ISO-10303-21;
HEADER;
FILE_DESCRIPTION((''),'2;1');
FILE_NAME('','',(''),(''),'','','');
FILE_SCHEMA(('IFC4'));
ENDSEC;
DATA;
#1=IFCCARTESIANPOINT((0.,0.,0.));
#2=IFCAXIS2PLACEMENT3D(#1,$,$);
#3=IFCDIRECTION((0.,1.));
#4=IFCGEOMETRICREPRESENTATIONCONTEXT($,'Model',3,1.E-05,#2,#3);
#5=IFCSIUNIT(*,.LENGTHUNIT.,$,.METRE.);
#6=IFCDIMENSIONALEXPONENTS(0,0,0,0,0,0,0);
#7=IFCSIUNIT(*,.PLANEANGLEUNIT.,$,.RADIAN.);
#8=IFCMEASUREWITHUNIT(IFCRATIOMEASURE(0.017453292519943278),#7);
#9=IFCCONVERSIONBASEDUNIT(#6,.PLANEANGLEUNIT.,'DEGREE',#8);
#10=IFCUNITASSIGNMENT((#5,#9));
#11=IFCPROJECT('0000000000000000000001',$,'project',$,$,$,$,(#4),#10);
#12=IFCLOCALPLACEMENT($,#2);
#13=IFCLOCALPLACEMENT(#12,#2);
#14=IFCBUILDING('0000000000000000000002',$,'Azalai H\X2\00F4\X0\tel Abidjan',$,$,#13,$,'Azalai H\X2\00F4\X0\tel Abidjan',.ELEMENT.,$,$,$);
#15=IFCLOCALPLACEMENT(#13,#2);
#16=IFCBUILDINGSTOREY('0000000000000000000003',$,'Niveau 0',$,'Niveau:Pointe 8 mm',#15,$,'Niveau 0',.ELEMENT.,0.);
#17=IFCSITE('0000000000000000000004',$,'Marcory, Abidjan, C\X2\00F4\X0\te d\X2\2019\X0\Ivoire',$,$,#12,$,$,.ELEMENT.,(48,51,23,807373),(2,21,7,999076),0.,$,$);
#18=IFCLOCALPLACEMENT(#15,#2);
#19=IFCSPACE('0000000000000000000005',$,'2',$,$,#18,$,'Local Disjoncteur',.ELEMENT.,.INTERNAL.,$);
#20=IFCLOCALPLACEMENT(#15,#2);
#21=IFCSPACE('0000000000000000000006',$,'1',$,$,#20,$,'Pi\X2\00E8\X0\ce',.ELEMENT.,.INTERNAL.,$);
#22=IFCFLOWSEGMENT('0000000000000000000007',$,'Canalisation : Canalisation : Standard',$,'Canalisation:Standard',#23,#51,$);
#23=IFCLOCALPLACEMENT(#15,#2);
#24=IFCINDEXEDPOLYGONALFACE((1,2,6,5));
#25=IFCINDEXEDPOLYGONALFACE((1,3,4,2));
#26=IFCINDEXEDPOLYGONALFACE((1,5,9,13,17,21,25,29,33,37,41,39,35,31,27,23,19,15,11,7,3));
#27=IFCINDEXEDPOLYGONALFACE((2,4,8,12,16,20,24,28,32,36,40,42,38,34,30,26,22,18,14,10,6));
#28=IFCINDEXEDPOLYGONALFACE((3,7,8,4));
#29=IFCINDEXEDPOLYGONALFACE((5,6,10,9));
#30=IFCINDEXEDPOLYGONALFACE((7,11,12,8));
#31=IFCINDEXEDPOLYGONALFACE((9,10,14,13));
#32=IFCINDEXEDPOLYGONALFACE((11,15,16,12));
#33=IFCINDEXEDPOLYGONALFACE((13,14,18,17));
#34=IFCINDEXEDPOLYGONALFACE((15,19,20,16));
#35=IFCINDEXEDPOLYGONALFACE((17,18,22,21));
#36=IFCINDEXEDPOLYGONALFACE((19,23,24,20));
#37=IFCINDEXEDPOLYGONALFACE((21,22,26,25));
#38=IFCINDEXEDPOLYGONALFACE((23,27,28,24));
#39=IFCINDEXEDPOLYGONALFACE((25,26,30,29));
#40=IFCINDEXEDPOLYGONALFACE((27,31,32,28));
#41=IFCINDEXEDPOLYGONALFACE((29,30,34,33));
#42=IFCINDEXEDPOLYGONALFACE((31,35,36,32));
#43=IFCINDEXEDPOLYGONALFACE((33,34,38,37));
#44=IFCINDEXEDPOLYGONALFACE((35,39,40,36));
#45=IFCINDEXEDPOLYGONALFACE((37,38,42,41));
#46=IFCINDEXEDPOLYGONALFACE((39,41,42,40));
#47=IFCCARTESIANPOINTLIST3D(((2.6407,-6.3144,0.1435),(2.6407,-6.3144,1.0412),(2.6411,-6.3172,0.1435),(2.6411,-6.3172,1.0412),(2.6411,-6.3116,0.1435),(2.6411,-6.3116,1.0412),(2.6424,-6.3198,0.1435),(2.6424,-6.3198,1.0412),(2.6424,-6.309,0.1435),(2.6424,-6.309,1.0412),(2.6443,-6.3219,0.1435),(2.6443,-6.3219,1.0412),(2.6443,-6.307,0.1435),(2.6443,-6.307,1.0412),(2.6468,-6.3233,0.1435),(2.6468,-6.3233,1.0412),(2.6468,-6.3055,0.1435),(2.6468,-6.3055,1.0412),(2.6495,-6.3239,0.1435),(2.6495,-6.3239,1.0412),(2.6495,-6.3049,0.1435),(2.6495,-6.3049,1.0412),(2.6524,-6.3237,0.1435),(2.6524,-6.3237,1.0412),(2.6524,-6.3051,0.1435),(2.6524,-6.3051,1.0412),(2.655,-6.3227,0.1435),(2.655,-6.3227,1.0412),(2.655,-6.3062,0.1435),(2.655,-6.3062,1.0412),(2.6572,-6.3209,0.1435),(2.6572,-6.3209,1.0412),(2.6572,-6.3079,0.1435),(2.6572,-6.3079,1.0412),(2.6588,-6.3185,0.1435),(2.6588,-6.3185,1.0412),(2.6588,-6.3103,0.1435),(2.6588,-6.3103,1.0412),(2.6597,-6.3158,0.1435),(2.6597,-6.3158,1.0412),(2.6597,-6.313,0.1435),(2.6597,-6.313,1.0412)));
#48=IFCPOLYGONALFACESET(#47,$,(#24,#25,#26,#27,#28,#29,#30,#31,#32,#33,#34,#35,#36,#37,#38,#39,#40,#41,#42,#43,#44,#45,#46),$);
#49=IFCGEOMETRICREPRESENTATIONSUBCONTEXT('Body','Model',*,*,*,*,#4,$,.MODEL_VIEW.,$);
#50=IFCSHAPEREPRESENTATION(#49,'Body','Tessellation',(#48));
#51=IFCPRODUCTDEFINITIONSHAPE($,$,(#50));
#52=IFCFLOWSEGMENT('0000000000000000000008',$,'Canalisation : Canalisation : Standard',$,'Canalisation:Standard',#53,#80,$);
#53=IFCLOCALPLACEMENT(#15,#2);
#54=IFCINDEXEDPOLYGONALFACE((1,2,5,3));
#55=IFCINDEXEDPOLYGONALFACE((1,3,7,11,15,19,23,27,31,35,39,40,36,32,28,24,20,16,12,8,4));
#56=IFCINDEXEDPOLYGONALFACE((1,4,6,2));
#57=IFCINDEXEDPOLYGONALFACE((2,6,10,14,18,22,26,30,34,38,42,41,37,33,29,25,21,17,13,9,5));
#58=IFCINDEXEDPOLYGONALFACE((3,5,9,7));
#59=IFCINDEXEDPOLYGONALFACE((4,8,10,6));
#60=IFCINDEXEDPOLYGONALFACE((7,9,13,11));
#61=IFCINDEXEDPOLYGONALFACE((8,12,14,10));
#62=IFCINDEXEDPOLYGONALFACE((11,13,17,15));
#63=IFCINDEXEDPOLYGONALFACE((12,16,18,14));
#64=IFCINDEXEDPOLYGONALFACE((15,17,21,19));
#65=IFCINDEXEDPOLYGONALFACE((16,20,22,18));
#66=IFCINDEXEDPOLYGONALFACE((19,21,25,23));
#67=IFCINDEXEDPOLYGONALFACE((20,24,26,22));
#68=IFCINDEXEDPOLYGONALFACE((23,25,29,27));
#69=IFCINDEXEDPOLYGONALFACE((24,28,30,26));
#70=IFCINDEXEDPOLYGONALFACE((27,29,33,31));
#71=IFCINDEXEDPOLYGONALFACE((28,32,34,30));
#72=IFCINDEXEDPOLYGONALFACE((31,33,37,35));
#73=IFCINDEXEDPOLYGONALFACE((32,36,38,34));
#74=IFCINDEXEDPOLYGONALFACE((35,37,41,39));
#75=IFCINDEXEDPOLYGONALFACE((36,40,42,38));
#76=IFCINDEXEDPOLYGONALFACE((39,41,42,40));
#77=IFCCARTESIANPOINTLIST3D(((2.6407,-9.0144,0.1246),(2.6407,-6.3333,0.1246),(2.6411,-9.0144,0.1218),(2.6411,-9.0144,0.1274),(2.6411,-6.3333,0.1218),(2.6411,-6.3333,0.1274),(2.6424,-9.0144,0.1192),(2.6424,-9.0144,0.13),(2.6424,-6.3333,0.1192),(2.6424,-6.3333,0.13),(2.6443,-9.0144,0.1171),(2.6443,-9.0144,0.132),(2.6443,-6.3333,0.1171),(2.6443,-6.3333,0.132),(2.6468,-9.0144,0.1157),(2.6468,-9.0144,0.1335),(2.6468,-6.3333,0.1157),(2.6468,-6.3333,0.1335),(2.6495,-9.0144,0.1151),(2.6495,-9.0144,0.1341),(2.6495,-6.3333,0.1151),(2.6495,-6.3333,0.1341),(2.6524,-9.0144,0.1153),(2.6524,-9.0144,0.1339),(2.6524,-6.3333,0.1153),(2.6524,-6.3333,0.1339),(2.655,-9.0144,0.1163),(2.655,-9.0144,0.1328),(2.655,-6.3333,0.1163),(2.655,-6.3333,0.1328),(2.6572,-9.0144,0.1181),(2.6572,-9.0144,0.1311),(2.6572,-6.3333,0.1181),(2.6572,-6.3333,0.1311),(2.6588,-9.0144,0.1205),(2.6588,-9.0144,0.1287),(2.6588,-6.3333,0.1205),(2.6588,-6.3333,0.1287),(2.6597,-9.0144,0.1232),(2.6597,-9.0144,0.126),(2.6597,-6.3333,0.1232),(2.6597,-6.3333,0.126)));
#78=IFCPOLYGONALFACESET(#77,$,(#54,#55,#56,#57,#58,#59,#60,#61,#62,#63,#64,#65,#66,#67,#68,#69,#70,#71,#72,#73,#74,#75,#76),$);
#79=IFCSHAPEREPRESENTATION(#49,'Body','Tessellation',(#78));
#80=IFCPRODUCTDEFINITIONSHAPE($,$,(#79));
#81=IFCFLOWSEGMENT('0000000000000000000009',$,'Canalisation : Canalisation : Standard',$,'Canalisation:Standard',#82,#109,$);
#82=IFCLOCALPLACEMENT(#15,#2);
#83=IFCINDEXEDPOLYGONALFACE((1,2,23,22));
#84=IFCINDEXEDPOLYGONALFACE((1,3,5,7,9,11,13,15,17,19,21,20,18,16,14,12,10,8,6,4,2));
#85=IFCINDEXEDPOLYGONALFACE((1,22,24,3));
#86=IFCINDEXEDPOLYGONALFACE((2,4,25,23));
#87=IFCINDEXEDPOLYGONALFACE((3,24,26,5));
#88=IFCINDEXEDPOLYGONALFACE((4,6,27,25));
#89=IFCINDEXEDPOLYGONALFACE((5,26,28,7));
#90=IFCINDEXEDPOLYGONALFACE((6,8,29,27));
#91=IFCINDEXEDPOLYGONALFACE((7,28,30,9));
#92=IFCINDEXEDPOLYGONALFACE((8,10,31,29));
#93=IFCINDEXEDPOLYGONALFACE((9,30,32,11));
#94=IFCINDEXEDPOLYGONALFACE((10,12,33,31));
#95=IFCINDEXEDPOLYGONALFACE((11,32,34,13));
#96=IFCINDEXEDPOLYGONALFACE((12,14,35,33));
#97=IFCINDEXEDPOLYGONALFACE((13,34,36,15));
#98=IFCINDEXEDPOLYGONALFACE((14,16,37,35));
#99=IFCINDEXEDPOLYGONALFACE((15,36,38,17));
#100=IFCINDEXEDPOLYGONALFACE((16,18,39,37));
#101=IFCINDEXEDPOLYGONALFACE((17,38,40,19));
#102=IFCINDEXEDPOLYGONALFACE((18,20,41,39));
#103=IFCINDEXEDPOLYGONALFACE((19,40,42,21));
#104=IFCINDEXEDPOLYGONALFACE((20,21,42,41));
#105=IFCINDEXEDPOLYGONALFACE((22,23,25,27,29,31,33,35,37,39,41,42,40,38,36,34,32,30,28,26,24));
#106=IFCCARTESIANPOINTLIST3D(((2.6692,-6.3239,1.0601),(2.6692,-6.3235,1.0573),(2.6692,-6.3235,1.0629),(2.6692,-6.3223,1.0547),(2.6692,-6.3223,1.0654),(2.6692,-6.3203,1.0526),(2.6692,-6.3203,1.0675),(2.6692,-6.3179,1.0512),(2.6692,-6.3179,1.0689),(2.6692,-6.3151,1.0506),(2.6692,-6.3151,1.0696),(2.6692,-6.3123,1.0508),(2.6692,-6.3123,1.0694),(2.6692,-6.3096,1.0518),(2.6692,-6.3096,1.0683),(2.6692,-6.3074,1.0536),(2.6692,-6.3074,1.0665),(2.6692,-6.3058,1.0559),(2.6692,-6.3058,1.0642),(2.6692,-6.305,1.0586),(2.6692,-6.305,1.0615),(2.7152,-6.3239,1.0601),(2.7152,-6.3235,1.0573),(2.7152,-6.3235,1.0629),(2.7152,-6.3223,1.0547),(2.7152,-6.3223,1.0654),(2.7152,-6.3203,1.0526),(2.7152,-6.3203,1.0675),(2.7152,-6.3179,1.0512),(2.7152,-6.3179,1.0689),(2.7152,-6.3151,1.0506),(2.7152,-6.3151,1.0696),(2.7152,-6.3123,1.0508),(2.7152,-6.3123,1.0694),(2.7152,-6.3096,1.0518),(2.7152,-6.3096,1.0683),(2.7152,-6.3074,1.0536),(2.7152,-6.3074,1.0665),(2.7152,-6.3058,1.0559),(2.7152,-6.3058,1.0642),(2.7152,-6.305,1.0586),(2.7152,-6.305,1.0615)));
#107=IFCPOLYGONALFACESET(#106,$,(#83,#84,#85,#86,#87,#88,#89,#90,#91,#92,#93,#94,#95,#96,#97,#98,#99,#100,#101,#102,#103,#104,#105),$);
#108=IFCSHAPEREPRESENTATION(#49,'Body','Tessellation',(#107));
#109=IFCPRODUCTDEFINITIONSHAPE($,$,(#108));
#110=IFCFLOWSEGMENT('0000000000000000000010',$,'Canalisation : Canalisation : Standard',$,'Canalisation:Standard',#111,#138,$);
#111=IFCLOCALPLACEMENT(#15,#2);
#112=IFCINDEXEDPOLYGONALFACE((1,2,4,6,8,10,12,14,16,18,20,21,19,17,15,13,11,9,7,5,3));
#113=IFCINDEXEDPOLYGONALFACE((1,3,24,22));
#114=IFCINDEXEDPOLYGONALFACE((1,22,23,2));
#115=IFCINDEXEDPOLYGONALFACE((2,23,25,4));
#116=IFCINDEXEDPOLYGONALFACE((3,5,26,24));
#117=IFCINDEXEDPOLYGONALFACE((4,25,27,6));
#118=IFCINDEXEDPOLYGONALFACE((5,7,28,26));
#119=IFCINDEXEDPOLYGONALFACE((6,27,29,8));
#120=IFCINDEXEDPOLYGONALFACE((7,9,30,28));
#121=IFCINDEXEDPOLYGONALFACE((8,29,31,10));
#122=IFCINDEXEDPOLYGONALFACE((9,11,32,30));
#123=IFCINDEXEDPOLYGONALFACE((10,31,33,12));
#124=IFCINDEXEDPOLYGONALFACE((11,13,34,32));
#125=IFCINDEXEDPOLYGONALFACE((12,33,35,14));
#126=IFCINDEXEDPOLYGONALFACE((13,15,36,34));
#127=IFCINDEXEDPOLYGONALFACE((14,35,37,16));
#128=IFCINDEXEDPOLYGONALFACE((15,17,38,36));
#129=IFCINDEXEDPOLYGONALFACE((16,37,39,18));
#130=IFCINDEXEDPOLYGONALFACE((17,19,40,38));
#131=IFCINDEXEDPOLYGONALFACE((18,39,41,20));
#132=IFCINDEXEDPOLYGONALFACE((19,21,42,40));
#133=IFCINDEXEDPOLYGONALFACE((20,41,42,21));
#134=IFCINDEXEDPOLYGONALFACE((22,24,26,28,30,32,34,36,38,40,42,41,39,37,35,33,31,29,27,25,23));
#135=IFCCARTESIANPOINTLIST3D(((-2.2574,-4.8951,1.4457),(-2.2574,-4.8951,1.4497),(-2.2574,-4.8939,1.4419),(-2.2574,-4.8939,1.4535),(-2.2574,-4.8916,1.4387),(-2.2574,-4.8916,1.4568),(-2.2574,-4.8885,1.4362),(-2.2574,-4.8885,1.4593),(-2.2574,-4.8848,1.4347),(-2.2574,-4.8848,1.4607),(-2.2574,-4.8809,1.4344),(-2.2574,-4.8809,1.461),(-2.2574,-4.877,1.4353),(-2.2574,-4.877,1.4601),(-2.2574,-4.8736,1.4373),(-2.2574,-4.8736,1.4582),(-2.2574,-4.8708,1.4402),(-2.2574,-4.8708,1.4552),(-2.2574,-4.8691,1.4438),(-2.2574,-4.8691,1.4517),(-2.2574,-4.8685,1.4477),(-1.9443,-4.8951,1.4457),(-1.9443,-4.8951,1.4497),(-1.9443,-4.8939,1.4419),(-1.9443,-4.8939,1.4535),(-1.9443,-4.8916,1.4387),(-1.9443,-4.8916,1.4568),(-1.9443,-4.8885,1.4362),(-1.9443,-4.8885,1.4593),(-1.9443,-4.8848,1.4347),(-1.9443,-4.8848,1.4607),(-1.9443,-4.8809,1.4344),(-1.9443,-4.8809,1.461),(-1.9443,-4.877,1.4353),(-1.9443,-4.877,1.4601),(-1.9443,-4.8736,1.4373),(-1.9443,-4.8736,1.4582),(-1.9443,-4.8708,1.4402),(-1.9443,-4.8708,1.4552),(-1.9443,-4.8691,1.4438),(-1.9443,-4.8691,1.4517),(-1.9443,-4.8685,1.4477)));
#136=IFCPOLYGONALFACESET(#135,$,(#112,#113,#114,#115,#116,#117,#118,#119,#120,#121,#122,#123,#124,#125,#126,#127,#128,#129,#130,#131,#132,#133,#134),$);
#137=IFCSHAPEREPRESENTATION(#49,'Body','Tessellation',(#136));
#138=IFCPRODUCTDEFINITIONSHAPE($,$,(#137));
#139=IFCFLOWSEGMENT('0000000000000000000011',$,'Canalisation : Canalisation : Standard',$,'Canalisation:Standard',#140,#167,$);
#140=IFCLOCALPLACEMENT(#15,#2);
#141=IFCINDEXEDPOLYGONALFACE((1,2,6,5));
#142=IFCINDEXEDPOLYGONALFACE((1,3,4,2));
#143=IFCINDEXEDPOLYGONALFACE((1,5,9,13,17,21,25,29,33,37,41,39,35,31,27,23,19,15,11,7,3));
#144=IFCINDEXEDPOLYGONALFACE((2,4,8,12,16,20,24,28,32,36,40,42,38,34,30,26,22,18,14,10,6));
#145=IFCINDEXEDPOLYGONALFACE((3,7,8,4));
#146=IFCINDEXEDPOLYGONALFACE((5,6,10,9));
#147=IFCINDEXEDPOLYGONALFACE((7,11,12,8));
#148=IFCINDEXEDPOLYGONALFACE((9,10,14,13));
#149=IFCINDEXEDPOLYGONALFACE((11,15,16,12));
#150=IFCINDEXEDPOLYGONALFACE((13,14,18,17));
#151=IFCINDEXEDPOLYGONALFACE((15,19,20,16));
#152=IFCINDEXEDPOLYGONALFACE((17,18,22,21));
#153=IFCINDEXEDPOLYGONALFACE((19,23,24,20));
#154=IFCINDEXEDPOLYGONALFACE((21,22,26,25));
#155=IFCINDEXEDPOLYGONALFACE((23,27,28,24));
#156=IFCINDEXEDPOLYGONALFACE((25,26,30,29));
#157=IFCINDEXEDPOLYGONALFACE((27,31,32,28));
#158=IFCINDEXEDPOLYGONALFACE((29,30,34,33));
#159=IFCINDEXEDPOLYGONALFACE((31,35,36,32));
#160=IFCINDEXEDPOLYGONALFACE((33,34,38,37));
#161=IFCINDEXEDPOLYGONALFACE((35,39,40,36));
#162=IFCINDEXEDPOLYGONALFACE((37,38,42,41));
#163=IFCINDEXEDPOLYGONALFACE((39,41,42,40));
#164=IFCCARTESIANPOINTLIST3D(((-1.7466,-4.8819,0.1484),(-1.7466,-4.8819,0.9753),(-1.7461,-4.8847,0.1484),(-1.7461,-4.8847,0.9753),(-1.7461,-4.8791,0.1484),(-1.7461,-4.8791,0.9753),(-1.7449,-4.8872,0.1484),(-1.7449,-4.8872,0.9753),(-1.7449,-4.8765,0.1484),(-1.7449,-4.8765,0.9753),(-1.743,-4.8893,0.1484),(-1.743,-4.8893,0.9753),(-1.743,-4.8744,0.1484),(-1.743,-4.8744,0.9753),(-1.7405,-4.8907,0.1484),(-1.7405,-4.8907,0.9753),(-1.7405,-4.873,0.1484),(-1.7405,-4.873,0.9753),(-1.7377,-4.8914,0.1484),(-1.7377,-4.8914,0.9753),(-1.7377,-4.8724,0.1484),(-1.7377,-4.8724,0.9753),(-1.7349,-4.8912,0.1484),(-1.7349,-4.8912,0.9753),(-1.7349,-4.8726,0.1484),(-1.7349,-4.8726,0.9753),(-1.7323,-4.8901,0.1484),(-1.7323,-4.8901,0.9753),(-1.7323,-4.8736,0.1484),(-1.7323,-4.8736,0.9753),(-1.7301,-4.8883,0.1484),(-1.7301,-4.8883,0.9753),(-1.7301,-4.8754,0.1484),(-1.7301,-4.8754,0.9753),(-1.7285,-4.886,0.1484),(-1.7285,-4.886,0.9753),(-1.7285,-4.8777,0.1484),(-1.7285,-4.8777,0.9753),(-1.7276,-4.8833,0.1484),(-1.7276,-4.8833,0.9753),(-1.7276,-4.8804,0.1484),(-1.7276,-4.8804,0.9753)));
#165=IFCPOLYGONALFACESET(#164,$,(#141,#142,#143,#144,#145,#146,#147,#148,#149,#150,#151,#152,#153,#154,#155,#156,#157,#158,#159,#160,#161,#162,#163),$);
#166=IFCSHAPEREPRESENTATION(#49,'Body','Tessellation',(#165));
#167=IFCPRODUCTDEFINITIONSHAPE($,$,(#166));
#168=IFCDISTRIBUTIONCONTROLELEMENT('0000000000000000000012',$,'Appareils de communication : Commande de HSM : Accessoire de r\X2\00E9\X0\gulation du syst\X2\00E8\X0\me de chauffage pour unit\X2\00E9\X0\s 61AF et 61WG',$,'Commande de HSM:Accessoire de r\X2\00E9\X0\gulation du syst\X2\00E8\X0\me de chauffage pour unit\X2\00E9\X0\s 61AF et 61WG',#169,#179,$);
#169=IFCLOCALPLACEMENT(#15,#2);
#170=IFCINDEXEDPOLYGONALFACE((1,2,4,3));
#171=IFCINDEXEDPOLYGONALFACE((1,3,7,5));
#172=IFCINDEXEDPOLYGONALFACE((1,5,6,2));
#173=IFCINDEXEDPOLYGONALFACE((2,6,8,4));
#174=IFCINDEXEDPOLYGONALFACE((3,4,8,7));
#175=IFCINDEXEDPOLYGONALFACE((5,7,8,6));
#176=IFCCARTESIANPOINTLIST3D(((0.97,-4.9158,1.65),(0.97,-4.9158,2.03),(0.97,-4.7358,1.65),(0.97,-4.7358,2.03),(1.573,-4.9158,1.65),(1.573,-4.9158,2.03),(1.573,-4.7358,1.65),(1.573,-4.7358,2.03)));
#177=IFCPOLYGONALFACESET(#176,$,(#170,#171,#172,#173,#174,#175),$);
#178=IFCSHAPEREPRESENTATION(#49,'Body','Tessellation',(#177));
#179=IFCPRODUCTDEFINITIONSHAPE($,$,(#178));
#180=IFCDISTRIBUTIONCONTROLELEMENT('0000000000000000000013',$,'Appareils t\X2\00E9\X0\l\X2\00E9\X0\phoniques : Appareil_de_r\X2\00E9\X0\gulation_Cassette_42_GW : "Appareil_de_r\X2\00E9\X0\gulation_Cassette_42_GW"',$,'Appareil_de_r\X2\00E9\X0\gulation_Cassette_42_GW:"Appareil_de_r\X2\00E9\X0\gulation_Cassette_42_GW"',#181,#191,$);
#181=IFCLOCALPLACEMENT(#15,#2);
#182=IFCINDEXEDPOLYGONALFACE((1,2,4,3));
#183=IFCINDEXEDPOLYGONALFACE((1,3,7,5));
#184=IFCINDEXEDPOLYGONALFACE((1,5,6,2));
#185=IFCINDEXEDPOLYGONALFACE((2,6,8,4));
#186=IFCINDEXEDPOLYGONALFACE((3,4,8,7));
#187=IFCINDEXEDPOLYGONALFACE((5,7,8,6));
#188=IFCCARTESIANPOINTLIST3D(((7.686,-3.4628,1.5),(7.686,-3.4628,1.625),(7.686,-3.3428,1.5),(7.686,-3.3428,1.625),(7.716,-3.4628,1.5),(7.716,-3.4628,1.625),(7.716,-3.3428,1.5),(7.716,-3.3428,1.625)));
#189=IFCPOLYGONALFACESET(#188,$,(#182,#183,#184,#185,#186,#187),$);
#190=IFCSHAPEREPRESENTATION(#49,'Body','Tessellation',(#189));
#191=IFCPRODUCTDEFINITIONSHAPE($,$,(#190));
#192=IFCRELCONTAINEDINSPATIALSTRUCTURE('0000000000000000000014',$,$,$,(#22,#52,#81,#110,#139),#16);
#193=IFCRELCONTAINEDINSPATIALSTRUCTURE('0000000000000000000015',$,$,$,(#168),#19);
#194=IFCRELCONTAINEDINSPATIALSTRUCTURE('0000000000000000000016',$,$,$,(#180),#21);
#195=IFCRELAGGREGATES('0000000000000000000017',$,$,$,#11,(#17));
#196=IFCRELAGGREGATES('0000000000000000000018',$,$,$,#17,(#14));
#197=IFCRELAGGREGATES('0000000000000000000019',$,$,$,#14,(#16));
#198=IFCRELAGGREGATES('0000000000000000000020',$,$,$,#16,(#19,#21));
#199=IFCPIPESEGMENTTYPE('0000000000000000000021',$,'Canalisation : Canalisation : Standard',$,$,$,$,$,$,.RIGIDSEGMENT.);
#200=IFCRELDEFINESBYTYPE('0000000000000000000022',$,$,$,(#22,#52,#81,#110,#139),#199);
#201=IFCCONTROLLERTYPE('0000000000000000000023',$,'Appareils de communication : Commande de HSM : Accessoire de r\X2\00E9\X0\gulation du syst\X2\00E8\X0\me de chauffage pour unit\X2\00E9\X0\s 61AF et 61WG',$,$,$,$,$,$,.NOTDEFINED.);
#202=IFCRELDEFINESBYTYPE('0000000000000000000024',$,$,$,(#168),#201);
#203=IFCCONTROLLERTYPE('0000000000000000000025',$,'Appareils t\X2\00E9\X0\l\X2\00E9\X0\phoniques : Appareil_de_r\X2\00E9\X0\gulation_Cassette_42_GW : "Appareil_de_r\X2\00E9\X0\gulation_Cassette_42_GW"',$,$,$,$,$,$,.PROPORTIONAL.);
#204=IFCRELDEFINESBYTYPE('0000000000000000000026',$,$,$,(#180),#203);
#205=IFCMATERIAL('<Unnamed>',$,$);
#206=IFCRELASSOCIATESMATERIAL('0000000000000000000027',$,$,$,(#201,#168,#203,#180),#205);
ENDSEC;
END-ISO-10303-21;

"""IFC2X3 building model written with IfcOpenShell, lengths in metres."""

from ifc_helpers import new_model, entity, si_unit, converted_unit, direction, frame, frame_2d, origin, origin_2d_with_axis, place, context, subcontext, project, spatial, rectangle, circle, extrude, source, transform, mapped, material, type_object, type_shapes, element, save


model = new_model("IFC2X3")

# Units and contexts
model_context = context("Model", 3, precision=1e-05, world=origin(), true_north=direction((0.0, 1.0)))
body_context = subcontext(model_context, "Body", "Model", "MODEL_VIEW")
ifc_project = project(units=[si_unit("LENGTHUNIT", "METRE"), converted_unit("PLANEANGLEUNIT", "DEGREE", entity("IfcRatioMeasure", 0.017453292519943278), si_unit("PLANEANGLEUNIT", "RADIAN"), dimensions=[0, 0, 0, 0, 0, 0, 0])], contexts=[model_context])

# Site, building, storey
site_placement = place(None, origin())
site = spatial("IfcSite", under=ifc_project, at=site_placement, Name="Marcory, Abidjan, Côte d’Ivoire", CompositionType="ELEMENT", RefLatitude=(48, 51, 23, 807373), RefLongitude=(2, 21, 7, 999076), RefElevation=0.0)
building_placement = place(site_placement, origin())
building = spatial("IfcBuilding", under=site, at=building_placement, Name="Azalai Hôtel Abidjan", LongName="Azalai Hôtel Abidjan", CompositionType="ELEMENT")
storey_placement = place(building_placement, origin())
storey = spatial("IfcBuildingStorey", under=building, at=storey_placement, Name="Niveau 0", ObjectType="Niveau:Pointe 8 mm", LongName="Niveau 0", CompositionType="ELEMENT", Elevation=0.0)

# Flow segments
pipe_segment_type = type_object("IfcPipeSegmentType", Name="Canalisation : Canalisation : Standard", PredefinedType="RIGIDSEGMENT")
flow_segment_1_placement = place(storey_placement, origin())
element("IfcFlowSegment", 1, at=flow_segment_1_placement, inside=storey, type_object=pipe_segment_type, Name="Canalisation : Canalisation : Standard", ObjectType="Canalisation:Standard", context=body_context, shape_type="SweptSolid", body=[
    extrude(circle(Radius=0.0095, at=origin_2d_with_axis()), frame((2.6502, -6.3144, 0.1435), z_axis=(0.0, 0.0, 1.0), x_axis=(-1.0, 0.0, 0.0)), (0.0, 0.0, 1.0), 0.8977),
])
flow_segment_2_placement = place(storey_placement, origin())
element("IfcFlowSegment", 2, at=flow_segment_2_placement, inside=storey, type_object=pipe_segment_type, Name="Canalisation : Canalisation : Standard", ObjectType="Canalisation:Standard", context=body_context, shape_type="SweptSolid", body=[
    extrude(circle(Radius=0.0095, at=frame_2d((0.0, 0.0), x_axis=(1.0, 0.0))), frame((2.6502, -9.0144, 0.1246), z_axis=(0.0, 1.0, 0.0), x_axis=(-1.0, 0.0, 0.0)), (0.0, 0.0, 1.0), 2.6811),
])
flow_segment_3_placement = place(storey_placement, origin())
element("IfcFlowSegment", 3, at=flow_segment_3_placement, inside=storey, type_object=pipe_segment_type, Name="Canalisation : Canalisation : Standard", ObjectType="Canalisation:Standard", context=body_context, shape_type="SweptSolid", body=[
    extrude(circle(Radius=0.0095, at=origin_2d_with_axis()), frame((2.6692, -6.3144, 1.0601), z_axis=(1.0, 0.0, 0.0), x_axis=(0.0, -1.0, 0.0)), (0.0, 0.0, 1.0), 0.0461),
])
flow_segment_4_placement = place(storey_placement, origin())
element("IfcFlowSegment", 4, at=flow_segment_4_placement, inside=storey, type_object=pipe_segment_type, Name="Canalisation : Canalisation : Standard", ObjectType="Canalisation:Standard", context=body_context, shape_type="SweptSolid", body=[
    extrude(circle(Radius=0.0133, at=frame_2d((0.0, 0.0), x_axis=(1.0, 0.0))), frame((-2.2574, -4.8819, 1.4477), z_axis=(1.0, 0.0, 0.0), x_axis=(0.0, 1.0, 0.0)), (0.0, 0.0, 1.0), 0.3131),
])
flow_segment_5_placement = place(storey_placement, origin())
element("IfcFlowSegment", 5, at=flow_segment_5_placement, inside=storey, type_object=pipe_segment_type, Name="Canalisation : Canalisation : Standard", ObjectType="Canalisation:Standard", context=body_context, shape_type="SweptSolid", body=[
    extrude(circle(Radius=0.0095, at=origin_2d_with_axis()), frame((-1.737, -4.8819, 0.1484), z_axis=(0.0, 0.0, 1.0), x_axis=(-1.0, 0.0, 0.0)), (0.0, 0.0, 1.0), 0.8269),
])

# Shared definitions
space_1_placement = place(storey_placement, origin())
space_1 = spatial("IfcSpace", under=storey, at=space_1_placement, Name="2", LongName="Local Disjoncteur", CompositionType="ELEMENT", InteriorOrExteriorSpace="INTERNAL")

# Distribution control element
ifc_material_1 = material(Name="<Unnamed>")
controller_type_1 = type_object("IfcControllerType", Name="Appareils de communication : Commande de HSM : Accessoire de régulation du système de chauffage pour unités 61AF et 61WG", PredefinedType="PROPORTIONALINTEGRALDERIVATIVE", material=ifc_material_1)
shared_shape_1 = source(origin(), body_context, "Body", "SweptSolid", [
    extrude(rectangle(XDim=0.603, YDim=0.18, at=origin_2d_with_axis()), frame((0.0, 0.0, 0.0), z_axis=(0.0, 0.0, 1.0), x_axis=(-1.0, 0.0, 0.0)), (0.0, 0.0, 1.0), 0.38),
])
type_shapes(controller_type_1, [shared_shape_1])
distribution_control_element_1_placement = place(space_1_placement, frame((1.2715, -4.8258, 1.65)))
element("IfcDistributionControlElement", 6, at=distribution_control_element_1_placement, inside=space_1, type_object=controller_type_1, material=ifc_material_1, Name="Appareils de communication : Commande de HSM : Accessoire de régulation du système de chauffage pour unités 61AF et 61WG", ObjectType="Commande de HSM:Accessoire de régulation du système de chauffage pour unités 61AF et 61WG", context=body_context, shape_type="MappedRepresentation", body=[
    mapped(shared_shape_1, transform((0.0, 0.0, 0.0), scale=1.0)),
])

# Shared definitions
space_2_placement = place(storey_placement, origin())
space_2 = spatial("IfcSpace", under=storey, at=space_2_placement, Name="1", LongName="Pièce", CompositionType="ELEMENT", InteriorOrExteriorSpace="INTERNAL")

# Distribution control element
controller_type_2 = type_object("IfcControllerType", Name="Appareils téléphoniques : Appareil_de_régulation_Cassette_42_GW : \"Appareil_de_régulation_Cassette_42_GW\"", PredefinedType="PROPORTIONAL", material=ifc_material_1)
shared_shape_2 = source(origin(), body_context, "Body", "SweptSolid", [
    extrude(rectangle(XDim=0.12, YDim=0.03, at=origin_2d_with_axis()), frame((0.0, 0.0, 0.0), z_axis=(0.0, 0.0, 1.0), x_axis=(-1.0, 0.0, 0.0)), (0.0, 0.0, 1.0), 0.125),
])
type_shapes(controller_type_2, [shared_shape_2])
distribution_control_element_2_placement = place(space_2_placement, frame((7.701, -3.4028, 1.5), z_axis=(0.0, 0.0, 1.0), x_axis=(0.0, 1.0, 0.0)))
element("IfcDistributionControlElement", 7, at=distribution_control_element_2_placement, inside=space_2, type_object=controller_type_2, material=ifc_material_1, Name="Appareils téléphoniques : Appareil_de_régulation_Cassette_42_GW : \"Appareil_de_régulation_Cassette_42_GW\"", ObjectType="Appareil_de_régulation_Cassette_42_GW:\"Appareil_de_régulation_Cassette_42_GW\"", context=body_context, shape_type="MappedRepresentation", body=[
    mapped(shared_shape_2, transform((0.0, 0.0, 0.0), scale=1.0)),
])

save(model, "model.ifc")
